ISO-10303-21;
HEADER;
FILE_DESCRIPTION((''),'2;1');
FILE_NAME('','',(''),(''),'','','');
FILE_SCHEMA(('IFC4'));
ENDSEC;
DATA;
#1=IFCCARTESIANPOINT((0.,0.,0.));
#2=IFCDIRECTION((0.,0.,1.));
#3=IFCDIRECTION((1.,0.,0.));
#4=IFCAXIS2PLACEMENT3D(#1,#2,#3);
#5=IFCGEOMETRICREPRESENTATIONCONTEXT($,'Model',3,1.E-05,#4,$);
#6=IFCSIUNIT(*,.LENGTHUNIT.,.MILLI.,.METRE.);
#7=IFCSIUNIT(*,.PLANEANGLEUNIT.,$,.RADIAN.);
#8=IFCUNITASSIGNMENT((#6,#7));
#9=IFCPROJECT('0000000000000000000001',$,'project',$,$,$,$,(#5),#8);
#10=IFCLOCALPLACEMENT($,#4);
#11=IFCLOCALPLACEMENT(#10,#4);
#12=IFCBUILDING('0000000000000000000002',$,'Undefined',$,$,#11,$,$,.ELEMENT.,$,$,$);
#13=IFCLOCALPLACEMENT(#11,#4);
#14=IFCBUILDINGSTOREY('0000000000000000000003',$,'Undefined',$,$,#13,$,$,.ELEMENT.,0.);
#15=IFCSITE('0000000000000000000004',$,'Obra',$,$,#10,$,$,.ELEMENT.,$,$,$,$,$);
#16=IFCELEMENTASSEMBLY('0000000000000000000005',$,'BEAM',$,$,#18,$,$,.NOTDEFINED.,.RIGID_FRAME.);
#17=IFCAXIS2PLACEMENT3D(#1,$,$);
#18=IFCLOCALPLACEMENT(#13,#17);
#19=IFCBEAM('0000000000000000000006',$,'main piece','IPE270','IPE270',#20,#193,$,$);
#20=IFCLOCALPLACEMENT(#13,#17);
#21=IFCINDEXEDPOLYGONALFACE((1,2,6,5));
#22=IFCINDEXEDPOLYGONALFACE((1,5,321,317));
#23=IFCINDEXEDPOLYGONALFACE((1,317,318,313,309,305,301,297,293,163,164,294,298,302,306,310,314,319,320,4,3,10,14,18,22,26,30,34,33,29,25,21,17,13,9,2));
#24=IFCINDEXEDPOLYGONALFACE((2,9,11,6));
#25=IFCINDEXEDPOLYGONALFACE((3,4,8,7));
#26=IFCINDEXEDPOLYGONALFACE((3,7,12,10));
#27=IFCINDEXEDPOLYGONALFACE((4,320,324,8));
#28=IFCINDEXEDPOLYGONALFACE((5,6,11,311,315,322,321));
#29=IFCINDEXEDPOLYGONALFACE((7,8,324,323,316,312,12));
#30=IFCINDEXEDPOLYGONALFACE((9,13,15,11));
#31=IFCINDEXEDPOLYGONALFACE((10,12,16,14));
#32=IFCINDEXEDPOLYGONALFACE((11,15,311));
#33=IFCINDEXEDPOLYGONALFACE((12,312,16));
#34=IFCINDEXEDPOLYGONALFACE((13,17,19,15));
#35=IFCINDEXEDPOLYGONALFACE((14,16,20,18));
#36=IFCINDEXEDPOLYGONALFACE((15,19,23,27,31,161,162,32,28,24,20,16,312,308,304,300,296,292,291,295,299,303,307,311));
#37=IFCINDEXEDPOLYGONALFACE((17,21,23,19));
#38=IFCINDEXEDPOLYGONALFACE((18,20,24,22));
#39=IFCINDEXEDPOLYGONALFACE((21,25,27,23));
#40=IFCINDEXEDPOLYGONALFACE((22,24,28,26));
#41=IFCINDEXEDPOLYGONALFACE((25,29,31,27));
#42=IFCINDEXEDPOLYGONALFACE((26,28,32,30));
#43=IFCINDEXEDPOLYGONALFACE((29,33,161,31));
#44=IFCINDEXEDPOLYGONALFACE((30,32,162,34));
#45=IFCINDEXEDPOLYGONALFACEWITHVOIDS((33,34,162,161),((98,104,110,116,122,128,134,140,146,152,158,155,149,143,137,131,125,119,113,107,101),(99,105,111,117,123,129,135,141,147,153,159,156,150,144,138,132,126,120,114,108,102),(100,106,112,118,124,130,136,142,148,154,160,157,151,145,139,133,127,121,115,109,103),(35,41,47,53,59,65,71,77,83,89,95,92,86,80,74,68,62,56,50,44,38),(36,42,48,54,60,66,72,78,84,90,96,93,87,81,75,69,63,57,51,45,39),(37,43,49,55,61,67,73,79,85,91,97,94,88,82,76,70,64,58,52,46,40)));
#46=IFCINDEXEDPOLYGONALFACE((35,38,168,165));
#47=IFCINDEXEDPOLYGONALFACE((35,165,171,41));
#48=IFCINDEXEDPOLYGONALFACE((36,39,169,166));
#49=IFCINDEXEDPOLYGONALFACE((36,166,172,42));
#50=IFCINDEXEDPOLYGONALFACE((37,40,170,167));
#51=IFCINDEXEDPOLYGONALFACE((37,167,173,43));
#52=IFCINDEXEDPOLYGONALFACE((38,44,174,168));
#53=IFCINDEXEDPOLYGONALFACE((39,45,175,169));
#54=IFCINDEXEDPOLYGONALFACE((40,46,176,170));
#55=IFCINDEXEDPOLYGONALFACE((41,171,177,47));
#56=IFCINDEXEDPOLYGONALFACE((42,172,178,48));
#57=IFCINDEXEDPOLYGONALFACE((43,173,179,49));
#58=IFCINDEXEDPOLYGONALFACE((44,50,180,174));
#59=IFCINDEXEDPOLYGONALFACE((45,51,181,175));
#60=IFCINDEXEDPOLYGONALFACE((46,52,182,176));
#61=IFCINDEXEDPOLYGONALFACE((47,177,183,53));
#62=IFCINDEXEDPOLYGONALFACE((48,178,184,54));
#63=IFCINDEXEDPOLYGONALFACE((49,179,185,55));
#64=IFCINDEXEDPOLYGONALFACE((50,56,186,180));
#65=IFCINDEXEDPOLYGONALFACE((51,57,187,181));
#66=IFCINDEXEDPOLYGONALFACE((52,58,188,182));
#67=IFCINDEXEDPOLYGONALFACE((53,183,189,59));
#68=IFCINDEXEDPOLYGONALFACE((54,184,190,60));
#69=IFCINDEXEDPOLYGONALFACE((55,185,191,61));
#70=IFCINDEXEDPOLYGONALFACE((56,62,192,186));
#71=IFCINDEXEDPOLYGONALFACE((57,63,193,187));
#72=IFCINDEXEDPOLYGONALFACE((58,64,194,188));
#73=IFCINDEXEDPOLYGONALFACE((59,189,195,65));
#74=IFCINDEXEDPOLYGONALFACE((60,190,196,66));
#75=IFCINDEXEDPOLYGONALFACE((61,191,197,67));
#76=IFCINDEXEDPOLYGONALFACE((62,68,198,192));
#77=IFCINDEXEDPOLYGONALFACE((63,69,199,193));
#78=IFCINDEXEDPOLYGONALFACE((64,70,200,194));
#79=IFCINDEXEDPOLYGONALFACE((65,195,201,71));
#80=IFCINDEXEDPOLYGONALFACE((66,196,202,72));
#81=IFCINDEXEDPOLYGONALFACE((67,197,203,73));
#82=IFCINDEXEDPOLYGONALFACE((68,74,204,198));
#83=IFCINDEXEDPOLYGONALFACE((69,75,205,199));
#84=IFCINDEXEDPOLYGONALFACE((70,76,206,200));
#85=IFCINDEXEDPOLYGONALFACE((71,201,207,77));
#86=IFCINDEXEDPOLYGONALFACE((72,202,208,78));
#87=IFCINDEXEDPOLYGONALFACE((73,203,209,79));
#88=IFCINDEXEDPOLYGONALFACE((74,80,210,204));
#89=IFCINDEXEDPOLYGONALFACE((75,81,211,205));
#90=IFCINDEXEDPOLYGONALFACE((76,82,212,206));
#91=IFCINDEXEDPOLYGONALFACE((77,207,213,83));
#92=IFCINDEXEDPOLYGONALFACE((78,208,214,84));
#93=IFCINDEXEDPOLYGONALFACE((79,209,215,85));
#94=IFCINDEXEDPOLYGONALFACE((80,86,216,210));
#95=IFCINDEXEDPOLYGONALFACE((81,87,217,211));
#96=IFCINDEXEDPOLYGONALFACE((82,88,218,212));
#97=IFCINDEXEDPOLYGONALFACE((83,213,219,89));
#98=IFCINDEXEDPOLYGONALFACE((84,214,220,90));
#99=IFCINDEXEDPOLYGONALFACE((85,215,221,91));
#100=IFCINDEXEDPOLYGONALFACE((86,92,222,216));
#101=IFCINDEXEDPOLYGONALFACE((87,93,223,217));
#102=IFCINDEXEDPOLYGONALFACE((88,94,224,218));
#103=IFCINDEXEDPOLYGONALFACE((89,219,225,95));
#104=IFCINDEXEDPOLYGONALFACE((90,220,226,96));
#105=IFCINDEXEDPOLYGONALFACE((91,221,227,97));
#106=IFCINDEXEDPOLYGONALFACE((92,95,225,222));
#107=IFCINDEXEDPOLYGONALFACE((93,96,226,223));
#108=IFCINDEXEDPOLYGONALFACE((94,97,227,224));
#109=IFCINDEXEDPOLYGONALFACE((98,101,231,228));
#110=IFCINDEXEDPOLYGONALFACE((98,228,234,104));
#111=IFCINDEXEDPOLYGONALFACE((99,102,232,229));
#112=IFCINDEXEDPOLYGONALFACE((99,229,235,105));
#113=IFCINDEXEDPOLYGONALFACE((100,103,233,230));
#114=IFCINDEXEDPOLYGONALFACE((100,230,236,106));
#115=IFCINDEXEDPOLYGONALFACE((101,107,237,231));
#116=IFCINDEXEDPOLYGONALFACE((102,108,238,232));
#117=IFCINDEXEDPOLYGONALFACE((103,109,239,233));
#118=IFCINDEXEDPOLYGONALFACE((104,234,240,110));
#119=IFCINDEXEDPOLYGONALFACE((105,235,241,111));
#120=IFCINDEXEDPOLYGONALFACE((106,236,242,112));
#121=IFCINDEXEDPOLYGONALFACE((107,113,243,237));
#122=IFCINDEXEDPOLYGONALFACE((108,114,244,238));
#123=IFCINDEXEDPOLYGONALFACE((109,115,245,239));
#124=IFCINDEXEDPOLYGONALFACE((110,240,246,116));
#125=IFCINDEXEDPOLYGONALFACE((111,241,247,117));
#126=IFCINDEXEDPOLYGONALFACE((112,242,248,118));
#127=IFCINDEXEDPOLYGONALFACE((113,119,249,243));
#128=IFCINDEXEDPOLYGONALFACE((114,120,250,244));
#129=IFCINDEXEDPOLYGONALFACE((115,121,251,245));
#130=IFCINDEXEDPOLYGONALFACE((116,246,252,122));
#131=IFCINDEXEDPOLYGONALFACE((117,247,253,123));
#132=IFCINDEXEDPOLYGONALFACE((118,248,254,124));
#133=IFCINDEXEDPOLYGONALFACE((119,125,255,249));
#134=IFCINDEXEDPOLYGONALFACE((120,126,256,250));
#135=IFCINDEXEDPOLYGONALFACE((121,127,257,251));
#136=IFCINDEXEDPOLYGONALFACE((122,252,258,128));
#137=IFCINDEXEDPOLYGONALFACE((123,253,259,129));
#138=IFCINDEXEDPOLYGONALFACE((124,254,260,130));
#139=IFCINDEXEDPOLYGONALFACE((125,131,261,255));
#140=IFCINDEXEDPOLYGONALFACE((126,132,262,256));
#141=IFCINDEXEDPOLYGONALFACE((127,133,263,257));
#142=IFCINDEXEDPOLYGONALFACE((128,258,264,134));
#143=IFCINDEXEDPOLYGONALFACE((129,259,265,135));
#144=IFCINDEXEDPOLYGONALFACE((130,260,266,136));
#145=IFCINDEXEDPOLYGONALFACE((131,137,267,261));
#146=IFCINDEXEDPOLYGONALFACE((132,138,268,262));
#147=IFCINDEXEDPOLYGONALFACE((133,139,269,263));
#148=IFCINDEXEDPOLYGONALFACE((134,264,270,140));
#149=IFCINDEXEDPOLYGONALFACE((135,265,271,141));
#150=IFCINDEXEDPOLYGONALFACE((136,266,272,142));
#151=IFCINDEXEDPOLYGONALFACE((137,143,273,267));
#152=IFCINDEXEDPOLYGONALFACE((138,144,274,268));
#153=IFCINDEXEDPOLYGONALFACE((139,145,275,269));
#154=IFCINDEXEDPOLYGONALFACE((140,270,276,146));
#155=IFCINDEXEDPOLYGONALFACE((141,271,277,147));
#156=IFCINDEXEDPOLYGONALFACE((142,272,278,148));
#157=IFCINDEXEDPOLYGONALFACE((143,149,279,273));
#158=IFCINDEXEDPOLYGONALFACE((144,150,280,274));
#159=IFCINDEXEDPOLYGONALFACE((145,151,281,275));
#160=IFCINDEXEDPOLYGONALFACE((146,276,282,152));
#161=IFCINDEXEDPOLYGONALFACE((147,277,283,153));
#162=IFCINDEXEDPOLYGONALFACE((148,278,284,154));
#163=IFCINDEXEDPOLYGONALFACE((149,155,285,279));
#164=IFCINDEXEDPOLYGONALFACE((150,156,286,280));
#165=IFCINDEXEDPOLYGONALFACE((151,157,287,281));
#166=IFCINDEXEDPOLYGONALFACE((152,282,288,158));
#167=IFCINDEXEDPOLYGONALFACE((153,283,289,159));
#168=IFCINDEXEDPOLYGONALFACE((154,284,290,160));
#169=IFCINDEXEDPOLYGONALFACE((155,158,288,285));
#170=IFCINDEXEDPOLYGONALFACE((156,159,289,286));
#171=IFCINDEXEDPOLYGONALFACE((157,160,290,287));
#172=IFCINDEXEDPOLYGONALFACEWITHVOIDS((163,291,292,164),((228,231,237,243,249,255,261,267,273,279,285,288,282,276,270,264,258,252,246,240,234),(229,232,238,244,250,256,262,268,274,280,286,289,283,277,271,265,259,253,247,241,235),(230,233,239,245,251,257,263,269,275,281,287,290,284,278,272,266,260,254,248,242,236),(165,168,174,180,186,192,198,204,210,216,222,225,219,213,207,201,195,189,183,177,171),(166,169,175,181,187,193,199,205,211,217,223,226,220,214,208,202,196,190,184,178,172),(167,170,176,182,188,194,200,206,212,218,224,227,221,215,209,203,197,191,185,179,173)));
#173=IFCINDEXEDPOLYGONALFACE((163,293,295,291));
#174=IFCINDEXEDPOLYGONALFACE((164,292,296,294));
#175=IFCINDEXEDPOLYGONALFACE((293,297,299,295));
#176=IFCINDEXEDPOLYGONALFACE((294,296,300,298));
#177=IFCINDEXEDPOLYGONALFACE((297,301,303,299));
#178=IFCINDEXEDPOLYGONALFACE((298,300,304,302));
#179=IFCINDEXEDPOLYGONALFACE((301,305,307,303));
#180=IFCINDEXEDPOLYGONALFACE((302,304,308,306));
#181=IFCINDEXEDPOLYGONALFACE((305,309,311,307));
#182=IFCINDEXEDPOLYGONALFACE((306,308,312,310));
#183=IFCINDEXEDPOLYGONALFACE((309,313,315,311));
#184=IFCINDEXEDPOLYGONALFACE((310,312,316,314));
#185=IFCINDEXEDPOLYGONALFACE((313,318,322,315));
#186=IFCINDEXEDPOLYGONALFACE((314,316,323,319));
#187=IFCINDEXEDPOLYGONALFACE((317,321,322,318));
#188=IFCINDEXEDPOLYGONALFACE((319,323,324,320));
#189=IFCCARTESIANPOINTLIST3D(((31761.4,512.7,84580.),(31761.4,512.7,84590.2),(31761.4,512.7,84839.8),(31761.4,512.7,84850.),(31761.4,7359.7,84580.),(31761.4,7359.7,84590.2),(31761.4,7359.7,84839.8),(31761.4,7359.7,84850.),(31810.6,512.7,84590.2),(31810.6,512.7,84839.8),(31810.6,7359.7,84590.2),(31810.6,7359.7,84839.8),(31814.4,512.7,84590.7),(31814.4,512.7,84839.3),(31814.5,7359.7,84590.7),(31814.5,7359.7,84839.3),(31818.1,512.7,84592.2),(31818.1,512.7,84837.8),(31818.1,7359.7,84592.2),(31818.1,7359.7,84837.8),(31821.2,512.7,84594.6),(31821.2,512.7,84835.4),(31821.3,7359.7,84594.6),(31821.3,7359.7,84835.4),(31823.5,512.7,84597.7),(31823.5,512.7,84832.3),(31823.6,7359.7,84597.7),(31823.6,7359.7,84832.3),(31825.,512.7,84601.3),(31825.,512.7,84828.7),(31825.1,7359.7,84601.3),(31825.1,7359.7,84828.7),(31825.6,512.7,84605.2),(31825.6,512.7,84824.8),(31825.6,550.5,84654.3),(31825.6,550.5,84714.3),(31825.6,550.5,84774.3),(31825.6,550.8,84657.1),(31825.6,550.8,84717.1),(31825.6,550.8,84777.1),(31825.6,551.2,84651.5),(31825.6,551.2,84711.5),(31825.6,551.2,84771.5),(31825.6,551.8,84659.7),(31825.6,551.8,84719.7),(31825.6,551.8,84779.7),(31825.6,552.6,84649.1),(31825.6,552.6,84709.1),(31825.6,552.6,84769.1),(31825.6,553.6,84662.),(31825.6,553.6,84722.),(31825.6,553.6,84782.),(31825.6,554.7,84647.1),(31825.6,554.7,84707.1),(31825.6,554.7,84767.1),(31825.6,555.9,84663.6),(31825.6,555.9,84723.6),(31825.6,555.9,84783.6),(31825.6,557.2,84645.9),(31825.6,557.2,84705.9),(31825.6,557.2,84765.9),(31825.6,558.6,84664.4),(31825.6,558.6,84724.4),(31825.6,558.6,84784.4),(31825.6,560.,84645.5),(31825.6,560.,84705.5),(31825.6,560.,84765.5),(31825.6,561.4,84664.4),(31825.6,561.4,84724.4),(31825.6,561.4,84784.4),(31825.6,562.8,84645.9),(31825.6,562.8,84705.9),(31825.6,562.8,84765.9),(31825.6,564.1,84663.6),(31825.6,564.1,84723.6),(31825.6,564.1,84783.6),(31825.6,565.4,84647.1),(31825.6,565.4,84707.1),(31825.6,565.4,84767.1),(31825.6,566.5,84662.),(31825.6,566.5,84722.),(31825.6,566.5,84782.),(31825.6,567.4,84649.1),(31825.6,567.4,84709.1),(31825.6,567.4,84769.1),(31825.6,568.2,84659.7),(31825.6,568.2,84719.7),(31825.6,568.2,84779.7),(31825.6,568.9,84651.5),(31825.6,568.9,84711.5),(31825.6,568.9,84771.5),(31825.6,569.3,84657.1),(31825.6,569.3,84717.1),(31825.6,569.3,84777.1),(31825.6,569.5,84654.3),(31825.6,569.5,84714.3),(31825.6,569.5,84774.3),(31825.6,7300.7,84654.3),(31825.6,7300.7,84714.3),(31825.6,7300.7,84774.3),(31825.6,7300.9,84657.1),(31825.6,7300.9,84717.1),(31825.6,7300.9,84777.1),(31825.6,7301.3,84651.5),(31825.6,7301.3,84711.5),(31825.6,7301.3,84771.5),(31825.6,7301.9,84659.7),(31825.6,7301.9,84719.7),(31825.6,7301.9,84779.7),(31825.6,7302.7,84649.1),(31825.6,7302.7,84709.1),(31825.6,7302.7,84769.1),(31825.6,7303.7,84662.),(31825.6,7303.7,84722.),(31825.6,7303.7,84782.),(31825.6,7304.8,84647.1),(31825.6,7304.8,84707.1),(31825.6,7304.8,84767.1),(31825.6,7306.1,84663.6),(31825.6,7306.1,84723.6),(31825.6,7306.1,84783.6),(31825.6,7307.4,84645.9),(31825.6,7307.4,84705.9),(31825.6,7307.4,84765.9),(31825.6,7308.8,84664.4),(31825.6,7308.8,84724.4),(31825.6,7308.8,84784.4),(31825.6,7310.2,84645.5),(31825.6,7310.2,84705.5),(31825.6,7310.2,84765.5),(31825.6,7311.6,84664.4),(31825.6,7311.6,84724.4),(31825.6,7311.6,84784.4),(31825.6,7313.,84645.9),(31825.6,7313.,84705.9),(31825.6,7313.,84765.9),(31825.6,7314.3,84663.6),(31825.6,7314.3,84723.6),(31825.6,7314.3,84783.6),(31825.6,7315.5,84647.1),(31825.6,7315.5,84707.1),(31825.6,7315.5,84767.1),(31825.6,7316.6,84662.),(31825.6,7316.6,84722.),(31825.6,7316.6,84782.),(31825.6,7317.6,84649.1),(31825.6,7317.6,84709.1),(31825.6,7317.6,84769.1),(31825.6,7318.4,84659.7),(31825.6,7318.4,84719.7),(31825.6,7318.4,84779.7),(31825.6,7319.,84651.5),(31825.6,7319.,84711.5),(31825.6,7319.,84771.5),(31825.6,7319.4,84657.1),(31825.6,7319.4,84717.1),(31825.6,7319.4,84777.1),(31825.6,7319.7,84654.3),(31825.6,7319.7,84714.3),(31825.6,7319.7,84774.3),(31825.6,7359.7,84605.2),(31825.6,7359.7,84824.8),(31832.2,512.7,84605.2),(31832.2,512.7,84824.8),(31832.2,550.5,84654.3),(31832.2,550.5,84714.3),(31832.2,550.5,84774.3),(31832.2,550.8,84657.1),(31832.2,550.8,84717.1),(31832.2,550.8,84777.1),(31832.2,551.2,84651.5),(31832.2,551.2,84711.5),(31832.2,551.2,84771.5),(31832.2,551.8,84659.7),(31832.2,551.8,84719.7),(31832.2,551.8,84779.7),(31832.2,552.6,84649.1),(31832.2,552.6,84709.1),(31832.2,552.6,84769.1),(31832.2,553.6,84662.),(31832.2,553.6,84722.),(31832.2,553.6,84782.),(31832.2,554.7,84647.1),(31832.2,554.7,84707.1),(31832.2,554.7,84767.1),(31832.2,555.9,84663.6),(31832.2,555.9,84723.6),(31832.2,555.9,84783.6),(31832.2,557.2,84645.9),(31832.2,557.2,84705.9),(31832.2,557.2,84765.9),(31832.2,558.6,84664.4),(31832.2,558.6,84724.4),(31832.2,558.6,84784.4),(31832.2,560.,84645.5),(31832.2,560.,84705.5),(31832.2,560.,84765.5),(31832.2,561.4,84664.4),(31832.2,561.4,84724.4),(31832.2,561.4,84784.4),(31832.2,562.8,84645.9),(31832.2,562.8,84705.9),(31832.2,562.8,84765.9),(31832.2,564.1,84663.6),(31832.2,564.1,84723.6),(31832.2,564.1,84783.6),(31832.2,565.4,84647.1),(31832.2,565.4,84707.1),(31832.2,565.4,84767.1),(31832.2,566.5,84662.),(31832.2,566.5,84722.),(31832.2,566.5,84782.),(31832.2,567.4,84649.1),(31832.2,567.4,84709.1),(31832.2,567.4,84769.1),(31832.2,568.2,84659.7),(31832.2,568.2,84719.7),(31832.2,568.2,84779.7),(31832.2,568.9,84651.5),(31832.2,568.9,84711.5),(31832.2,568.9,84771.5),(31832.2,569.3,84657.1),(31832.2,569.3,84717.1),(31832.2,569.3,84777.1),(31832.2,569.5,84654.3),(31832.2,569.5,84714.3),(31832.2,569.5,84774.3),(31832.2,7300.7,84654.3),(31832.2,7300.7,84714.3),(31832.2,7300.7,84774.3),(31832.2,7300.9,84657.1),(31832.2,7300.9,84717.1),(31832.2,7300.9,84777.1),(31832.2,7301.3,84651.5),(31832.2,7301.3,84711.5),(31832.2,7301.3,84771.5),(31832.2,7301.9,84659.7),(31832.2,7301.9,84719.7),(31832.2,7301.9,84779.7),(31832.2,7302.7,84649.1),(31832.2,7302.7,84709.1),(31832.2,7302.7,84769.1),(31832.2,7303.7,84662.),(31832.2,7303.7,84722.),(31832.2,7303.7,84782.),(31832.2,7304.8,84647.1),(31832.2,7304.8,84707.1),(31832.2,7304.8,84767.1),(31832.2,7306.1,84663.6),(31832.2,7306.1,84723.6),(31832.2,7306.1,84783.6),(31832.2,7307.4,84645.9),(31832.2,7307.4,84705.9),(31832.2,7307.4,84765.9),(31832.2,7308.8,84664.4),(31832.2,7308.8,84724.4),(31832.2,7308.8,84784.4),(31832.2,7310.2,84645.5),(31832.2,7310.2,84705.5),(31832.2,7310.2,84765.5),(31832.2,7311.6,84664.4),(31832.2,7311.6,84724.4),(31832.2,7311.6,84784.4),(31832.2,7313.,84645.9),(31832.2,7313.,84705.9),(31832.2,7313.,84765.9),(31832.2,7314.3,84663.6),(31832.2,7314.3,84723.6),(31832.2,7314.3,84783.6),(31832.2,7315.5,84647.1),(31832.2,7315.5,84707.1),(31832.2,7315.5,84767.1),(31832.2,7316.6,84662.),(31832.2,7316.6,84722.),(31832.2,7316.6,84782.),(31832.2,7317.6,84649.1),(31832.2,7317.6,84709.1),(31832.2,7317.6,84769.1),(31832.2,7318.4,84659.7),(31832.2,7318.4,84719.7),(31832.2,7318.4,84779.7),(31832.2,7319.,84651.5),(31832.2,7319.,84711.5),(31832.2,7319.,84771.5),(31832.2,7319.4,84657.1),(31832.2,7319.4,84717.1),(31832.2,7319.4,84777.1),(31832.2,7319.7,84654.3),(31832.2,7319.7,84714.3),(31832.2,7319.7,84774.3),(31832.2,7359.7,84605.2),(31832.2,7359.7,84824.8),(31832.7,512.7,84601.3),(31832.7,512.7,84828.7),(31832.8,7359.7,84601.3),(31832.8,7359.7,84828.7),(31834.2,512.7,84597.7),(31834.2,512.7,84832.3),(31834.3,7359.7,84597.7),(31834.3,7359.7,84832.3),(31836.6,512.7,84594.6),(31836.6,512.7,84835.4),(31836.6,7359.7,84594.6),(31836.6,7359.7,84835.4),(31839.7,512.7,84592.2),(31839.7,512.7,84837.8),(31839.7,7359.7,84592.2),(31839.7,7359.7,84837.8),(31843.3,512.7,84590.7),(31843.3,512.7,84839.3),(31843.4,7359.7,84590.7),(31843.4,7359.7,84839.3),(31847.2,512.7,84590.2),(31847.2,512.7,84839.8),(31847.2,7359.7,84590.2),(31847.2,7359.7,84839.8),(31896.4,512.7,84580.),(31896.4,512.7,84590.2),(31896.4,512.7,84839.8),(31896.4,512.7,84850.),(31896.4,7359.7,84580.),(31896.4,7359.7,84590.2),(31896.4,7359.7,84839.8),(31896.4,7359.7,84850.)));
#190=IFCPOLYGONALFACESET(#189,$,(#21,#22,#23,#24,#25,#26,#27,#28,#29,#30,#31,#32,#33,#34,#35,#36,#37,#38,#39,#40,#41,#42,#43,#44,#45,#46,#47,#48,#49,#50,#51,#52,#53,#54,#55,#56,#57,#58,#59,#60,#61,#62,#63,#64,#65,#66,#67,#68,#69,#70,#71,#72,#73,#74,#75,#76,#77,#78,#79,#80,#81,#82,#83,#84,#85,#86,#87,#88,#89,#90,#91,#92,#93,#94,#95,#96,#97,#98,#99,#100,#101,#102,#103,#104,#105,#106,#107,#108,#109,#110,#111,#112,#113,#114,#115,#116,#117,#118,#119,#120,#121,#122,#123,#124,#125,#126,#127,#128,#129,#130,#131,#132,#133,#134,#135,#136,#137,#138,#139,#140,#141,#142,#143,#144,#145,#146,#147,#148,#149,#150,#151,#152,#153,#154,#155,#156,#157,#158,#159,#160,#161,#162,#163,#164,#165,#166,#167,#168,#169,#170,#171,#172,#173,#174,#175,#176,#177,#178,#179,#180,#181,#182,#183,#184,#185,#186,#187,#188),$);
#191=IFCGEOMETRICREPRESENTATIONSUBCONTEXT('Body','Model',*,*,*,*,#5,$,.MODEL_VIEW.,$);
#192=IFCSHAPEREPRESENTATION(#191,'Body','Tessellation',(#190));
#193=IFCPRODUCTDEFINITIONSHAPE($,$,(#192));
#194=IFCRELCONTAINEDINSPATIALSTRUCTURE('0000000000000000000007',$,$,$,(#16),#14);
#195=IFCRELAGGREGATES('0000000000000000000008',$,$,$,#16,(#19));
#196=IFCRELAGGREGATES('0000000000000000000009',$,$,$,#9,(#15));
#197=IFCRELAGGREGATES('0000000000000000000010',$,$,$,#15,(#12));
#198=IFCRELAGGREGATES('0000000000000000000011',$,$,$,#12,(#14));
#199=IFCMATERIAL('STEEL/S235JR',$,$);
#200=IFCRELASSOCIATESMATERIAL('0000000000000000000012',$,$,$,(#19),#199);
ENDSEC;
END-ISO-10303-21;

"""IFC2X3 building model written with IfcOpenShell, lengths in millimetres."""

from ifc_helpers import new_model, si_unit, frame, origin_with_axes, origin_2d_with_axis, place, context, subcontext, project, spatial, circle, i_section, extrude, clip, halfspace, source, transform, mapped, material, element, aggregate, save


model = new_model("IFC2X3")

# Units and contexts
model_context = context("Model", 3, precision=1e-05, world=origin_with_axes())
body_context = subcontext(model_context, "Body", "Model", "MODEL_VIEW")
ifc_project = project(units=[si_unit("LENGTHUNIT", "METRE", prefix="MILLI"), si_unit("PLANEANGLEUNIT", "RADIAN")], contexts=[model_context])

# Site, building, storey
site_placement = place(None, origin_with_axes())
site = spatial("IfcSite", under=ifc_project, at=site_placement, Name="Obra", CompositionType="ELEMENT")
building_placement = place(site_placement, origin_with_axes())
building = spatial("IfcBuilding", under=site, at=building_placement, Name="Undefined", CompositionType="ELEMENT")
storey_placement = place(building_placement, origin_with_axes())
storey = spatial("IfcBuildingStorey", under=building, at=storey_placement, Name="Undefined", CompositionType="ELEMENT", Elevation=0.0)

# Element assembly, beam, openings
ifc_material_1 = material(Name="STEEL/S235JR")
assembly_1_placement = place(storey_placement, origin_with_axes())
assembly_1 = element("IfcElementAssembly", 1, at=assembly_1_placement, inside=storey, Name="BEAM", AssemblyPlace="NOTDEFINED", PredefinedType="RIGID_FRAME")
beam_1_placement = place(assembly_1_placement, frame((31828.9, 512.7, 84715.0), z_axis=(0.0, 0.0, 1.0), x_axis=(0.000013, 1.0, 0.0)))
beam_1 = element("IfcBeam", 2, at=beam_1_placement, material=ifc_material_1, Name="main piece", Description="IPE270", ObjectType="IPE270", context=body_context, shape_type="Clipping", body=[
    clip(clip(extrude(i_section(OverallWidth=135.0, OverallDepth=270.0, WebThickness=6.6, FlangeThickness=10.2, FilletRadius=15.0, at=origin_2d_with_axis()), frame((6857.4, 0.0, 0.0), z_axis=(-1.0, 0.0, 0.0), x_axis=(0.0, -1.0, 0.0)), (0.0, 0.0, 1.0), 6857.4), halfspace(frame((6847.0, -60.0, -120.0), z_axis=(1.0, 0.000037, 0.0), x_axis=(0.0, 0.0, 1.0)), False)), halfspace(frame((-2.2, 60.0, -120.0), z_axis=(-1.0, -0.000034, 0.0), x_axis=(0.0, 0.0, 1.0)), False)),
])
shared_shape_1 = source(origin_with_axes(), body_context, "Body", "SweptSolid", [
    extrude(circle(Radius=9.5, at=origin_2d_with_axis()), frame((0.0, -3.4, 0.0), z_axis=(0.0, 1.0, 0.0), x_axis=(1.0, 0.0, 0.0)), (0.0, 0.0, 1.0), 6.8),
])
opening_1_placement = place(assembly_1_placement, frame((31829.0, 7360.2, 84835.0), z_axis=(0.000005, -1.0, 0.0), x_axis=(0.0, 0.0, -1.0)))
element("IfcOpeningElement", 3, at=opening_1_placement, cuts=beam_1, ObjectType="Opening", context=body_context, shape_type="MappedRepresentation", body=[
    mapped(shared_shape_1, transform((60.0, 0.0, 50.0))),
    mapped(shared_shape_1, transform((120.0, 0.0, 50.0))),
    mapped(shared_shape_1, transform((180.0, 0.0, 50.0))),
])
shared_shape_2 = source(origin_with_axes(), body_context, "Body", "SweptSolid", [
    extrude(circle(Radius=9.5, at=origin_2d_with_axis()), frame((0.0, -3.4, 0.0), z_axis=(0.0, 1.0, 0.0), x_axis=(1.0, 0.0, 0.0)), (0.0, 0.0, 1.0), 6.8),
])
opening_2_placement = place(assembly_1_placement, frame((31828.9, 510.0, 84835.0), z_axis=(-0.000002, 1.0, 0.0), x_axis=(0.0, 0.0, -1.0)))
element("IfcOpeningElement", 4, at=opening_2_placement, cuts=beam_1, ObjectType="Opening", context=body_context, shape_type="MappedRepresentation", body=[
    mapped(shared_shape_2, transform((60.0, 0.0, 50.0))),
    mapped(shared_shape_2, transform((120.0, 0.0, 50.0))),
    mapped(shared_shape_2, transform((180.0, 0.0, 50.0))),
])
aggregate(assembly_1, [beam_1])

save(model, "model.ifc")
